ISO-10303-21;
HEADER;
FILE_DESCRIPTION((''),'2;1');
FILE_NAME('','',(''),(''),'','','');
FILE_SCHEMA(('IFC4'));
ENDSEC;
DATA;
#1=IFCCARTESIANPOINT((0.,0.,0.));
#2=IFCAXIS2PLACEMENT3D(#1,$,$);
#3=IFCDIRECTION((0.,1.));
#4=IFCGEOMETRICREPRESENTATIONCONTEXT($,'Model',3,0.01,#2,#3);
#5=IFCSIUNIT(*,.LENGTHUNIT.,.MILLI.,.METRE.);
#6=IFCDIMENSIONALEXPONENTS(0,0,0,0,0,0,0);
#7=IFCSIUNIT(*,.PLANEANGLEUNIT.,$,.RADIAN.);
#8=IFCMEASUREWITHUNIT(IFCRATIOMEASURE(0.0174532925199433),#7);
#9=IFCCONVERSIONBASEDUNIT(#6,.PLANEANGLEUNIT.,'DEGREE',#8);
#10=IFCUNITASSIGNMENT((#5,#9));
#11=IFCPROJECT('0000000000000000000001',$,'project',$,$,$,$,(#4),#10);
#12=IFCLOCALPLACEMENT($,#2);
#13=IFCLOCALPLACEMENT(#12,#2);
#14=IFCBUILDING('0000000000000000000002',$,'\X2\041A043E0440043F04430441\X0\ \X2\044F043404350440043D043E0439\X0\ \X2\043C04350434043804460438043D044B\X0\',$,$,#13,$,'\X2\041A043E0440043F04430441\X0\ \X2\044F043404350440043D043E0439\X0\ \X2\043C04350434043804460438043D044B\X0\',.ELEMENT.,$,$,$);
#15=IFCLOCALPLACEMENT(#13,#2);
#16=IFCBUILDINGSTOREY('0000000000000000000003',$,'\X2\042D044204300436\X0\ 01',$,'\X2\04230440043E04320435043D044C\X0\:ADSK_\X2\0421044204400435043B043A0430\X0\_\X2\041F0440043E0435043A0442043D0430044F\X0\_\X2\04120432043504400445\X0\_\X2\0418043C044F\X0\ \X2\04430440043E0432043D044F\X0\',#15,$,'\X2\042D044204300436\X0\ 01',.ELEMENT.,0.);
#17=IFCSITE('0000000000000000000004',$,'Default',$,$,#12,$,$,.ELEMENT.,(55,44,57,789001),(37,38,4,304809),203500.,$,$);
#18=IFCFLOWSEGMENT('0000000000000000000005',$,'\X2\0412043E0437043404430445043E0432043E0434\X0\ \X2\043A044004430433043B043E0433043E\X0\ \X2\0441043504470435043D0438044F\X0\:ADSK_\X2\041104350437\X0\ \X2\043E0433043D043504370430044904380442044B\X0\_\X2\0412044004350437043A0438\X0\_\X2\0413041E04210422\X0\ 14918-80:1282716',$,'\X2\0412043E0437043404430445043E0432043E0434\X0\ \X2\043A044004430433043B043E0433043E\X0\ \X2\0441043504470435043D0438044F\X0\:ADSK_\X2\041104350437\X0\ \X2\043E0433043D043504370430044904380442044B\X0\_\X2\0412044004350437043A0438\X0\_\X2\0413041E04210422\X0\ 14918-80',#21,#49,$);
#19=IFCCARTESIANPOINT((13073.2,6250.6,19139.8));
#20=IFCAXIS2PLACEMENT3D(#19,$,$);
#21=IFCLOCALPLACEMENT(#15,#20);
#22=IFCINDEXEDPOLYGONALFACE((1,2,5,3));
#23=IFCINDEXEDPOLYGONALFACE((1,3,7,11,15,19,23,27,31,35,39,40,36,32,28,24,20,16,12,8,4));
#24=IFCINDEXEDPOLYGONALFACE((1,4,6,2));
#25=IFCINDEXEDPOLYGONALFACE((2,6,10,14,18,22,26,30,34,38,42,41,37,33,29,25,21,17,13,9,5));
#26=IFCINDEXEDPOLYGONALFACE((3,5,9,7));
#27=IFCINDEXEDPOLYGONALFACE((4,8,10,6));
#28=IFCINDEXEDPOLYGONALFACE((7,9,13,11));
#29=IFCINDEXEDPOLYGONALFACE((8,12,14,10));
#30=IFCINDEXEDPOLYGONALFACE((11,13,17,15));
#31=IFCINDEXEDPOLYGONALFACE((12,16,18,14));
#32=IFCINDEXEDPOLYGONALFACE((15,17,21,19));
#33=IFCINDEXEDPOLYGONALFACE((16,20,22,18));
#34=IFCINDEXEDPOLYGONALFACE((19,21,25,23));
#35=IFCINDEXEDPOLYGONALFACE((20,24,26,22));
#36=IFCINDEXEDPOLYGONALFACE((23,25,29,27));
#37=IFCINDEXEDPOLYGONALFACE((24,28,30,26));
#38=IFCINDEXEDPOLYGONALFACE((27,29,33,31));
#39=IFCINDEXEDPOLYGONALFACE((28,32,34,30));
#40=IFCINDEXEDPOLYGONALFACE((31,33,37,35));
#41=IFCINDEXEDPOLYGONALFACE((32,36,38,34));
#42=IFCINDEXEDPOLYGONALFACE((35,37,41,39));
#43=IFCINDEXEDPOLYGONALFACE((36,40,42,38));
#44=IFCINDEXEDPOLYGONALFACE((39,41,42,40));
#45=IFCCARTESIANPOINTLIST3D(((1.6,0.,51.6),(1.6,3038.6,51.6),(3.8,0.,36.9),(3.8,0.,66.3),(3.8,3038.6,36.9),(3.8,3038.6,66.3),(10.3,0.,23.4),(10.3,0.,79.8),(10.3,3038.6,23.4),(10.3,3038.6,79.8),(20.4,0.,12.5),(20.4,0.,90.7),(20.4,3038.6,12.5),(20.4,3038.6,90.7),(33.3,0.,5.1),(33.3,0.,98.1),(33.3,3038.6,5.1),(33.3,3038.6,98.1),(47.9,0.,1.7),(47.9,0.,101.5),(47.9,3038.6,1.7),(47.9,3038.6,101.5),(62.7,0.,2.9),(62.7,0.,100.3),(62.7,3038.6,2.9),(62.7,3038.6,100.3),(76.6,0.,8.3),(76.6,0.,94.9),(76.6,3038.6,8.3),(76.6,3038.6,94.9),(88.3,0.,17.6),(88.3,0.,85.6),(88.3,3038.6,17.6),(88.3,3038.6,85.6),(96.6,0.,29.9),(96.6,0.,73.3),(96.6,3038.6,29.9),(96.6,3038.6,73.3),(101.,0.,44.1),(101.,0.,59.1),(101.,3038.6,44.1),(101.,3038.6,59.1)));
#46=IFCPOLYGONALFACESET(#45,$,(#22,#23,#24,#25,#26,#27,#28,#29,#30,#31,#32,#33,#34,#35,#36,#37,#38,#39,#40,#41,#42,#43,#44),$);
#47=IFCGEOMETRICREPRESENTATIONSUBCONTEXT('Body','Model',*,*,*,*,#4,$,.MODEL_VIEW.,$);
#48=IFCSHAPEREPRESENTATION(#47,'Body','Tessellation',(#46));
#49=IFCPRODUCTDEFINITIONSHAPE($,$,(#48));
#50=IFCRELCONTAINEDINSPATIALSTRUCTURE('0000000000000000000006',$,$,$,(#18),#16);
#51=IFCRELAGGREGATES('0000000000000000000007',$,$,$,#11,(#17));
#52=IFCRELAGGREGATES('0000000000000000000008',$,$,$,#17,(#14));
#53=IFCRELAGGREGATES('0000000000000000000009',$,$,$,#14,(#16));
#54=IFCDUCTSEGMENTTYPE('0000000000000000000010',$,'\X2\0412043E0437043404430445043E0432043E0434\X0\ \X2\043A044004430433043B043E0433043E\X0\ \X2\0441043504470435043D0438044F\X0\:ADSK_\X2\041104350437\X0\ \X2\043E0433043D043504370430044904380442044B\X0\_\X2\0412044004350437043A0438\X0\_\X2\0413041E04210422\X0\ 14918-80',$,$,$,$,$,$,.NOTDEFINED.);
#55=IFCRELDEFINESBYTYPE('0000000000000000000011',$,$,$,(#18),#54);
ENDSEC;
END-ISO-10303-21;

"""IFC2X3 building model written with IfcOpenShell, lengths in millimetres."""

from ifc_helpers import new_model, entity, si_unit, converted_unit, direction, frame, origin, origin_2d_with_axis, place, context, subcontext, project, spatial, circle, extrude, type_object, element, save


model = new_model("IFC2X3")

# Units and contexts
model_context = context("Model", 3, precision=0.01, world=origin(), true_north=direction((0.0, 1.0)))
body_context = subcontext(model_context, "Body", "Model", "MODEL_VIEW")
ifc_project = project(units=[si_unit("LENGTHUNIT", "METRE", prefix="MILLI"), converted_unit("PLANEANGLEUNIT", "DEGREE", entity("IfcRatioMeasure", 0.0174532925199433), si_unit("PLANEANGLEUNIT", "RADIAN"), dimensions=[0, 0, 0, 0, 0, 0, 0])], contexts=[model_context])

# Site, building, storey
site_placement = place(None, origin())
site = spatial("IfcSite", under=ifc_project, at=site_placement, Name="Default", CompositionType="ELEMENT", RefLatitude=(55, 44, 57, 789001), RefLongitude=(37, 38, 4, 304809), RefElevation=203500.0)
building_placement = place(site_placement, origin())
building = spatial("IfcBuilding", under=site, at=building_placement, Name="Корпус ядерной медицины", LongName="Корпус ядерной медицины", CompositionType="ELEMENT")
storey_placement = place(building_placement, origin())
storey = spatial("IfcBuildingStorey", under=building, at=storey_placement, Name="Этаж 01", ObjectType="Уровень:ADSK_Стрелка_Проектная_Вверх_Имя уровня", LongName="Этаж 01", CompositionType="ELEMENT", Elevation=0.0)

# Flow segment
duct_segment_type_1 = type_object("IfcDuctSegmentType", Name="Воздуховод круглого сечения:ADSK_Без огнезащиты_Врезки_ГОСТ 14918-80", PredefinedType="NOTDEFINED")
flow_segment_1_placement = place(storey_placement, frame((13073.2, 6250.6, 19139.8)))
element("IfcFlowSegment", 1, at=flow_segment_1_placement, inside=storey, type_object=duct_segment_type_1, Name="Воздуховод круглого сечения:ADSK_Без огнезащиты_Врезки_ГОСТ 14918-80:1282716", ObjectType="Воздуховод круглого сечения:ADSK_Без огнезащиты_Врезки_ГОСТ 14918-80", context=body_context, shape_type="SweptSolid", body=[
    extrude(circle(Radius=50.0, at=origin_2d_with_axis()), frame((51.6, 0.0, 51.6), z_axis=(0.0, 1.0, 0.0), x_axis=(-1.0, 0.0, 0.0)), (0.0, 0.0, 1.0), 3038.6),
])

save(model, "model.ifc")
